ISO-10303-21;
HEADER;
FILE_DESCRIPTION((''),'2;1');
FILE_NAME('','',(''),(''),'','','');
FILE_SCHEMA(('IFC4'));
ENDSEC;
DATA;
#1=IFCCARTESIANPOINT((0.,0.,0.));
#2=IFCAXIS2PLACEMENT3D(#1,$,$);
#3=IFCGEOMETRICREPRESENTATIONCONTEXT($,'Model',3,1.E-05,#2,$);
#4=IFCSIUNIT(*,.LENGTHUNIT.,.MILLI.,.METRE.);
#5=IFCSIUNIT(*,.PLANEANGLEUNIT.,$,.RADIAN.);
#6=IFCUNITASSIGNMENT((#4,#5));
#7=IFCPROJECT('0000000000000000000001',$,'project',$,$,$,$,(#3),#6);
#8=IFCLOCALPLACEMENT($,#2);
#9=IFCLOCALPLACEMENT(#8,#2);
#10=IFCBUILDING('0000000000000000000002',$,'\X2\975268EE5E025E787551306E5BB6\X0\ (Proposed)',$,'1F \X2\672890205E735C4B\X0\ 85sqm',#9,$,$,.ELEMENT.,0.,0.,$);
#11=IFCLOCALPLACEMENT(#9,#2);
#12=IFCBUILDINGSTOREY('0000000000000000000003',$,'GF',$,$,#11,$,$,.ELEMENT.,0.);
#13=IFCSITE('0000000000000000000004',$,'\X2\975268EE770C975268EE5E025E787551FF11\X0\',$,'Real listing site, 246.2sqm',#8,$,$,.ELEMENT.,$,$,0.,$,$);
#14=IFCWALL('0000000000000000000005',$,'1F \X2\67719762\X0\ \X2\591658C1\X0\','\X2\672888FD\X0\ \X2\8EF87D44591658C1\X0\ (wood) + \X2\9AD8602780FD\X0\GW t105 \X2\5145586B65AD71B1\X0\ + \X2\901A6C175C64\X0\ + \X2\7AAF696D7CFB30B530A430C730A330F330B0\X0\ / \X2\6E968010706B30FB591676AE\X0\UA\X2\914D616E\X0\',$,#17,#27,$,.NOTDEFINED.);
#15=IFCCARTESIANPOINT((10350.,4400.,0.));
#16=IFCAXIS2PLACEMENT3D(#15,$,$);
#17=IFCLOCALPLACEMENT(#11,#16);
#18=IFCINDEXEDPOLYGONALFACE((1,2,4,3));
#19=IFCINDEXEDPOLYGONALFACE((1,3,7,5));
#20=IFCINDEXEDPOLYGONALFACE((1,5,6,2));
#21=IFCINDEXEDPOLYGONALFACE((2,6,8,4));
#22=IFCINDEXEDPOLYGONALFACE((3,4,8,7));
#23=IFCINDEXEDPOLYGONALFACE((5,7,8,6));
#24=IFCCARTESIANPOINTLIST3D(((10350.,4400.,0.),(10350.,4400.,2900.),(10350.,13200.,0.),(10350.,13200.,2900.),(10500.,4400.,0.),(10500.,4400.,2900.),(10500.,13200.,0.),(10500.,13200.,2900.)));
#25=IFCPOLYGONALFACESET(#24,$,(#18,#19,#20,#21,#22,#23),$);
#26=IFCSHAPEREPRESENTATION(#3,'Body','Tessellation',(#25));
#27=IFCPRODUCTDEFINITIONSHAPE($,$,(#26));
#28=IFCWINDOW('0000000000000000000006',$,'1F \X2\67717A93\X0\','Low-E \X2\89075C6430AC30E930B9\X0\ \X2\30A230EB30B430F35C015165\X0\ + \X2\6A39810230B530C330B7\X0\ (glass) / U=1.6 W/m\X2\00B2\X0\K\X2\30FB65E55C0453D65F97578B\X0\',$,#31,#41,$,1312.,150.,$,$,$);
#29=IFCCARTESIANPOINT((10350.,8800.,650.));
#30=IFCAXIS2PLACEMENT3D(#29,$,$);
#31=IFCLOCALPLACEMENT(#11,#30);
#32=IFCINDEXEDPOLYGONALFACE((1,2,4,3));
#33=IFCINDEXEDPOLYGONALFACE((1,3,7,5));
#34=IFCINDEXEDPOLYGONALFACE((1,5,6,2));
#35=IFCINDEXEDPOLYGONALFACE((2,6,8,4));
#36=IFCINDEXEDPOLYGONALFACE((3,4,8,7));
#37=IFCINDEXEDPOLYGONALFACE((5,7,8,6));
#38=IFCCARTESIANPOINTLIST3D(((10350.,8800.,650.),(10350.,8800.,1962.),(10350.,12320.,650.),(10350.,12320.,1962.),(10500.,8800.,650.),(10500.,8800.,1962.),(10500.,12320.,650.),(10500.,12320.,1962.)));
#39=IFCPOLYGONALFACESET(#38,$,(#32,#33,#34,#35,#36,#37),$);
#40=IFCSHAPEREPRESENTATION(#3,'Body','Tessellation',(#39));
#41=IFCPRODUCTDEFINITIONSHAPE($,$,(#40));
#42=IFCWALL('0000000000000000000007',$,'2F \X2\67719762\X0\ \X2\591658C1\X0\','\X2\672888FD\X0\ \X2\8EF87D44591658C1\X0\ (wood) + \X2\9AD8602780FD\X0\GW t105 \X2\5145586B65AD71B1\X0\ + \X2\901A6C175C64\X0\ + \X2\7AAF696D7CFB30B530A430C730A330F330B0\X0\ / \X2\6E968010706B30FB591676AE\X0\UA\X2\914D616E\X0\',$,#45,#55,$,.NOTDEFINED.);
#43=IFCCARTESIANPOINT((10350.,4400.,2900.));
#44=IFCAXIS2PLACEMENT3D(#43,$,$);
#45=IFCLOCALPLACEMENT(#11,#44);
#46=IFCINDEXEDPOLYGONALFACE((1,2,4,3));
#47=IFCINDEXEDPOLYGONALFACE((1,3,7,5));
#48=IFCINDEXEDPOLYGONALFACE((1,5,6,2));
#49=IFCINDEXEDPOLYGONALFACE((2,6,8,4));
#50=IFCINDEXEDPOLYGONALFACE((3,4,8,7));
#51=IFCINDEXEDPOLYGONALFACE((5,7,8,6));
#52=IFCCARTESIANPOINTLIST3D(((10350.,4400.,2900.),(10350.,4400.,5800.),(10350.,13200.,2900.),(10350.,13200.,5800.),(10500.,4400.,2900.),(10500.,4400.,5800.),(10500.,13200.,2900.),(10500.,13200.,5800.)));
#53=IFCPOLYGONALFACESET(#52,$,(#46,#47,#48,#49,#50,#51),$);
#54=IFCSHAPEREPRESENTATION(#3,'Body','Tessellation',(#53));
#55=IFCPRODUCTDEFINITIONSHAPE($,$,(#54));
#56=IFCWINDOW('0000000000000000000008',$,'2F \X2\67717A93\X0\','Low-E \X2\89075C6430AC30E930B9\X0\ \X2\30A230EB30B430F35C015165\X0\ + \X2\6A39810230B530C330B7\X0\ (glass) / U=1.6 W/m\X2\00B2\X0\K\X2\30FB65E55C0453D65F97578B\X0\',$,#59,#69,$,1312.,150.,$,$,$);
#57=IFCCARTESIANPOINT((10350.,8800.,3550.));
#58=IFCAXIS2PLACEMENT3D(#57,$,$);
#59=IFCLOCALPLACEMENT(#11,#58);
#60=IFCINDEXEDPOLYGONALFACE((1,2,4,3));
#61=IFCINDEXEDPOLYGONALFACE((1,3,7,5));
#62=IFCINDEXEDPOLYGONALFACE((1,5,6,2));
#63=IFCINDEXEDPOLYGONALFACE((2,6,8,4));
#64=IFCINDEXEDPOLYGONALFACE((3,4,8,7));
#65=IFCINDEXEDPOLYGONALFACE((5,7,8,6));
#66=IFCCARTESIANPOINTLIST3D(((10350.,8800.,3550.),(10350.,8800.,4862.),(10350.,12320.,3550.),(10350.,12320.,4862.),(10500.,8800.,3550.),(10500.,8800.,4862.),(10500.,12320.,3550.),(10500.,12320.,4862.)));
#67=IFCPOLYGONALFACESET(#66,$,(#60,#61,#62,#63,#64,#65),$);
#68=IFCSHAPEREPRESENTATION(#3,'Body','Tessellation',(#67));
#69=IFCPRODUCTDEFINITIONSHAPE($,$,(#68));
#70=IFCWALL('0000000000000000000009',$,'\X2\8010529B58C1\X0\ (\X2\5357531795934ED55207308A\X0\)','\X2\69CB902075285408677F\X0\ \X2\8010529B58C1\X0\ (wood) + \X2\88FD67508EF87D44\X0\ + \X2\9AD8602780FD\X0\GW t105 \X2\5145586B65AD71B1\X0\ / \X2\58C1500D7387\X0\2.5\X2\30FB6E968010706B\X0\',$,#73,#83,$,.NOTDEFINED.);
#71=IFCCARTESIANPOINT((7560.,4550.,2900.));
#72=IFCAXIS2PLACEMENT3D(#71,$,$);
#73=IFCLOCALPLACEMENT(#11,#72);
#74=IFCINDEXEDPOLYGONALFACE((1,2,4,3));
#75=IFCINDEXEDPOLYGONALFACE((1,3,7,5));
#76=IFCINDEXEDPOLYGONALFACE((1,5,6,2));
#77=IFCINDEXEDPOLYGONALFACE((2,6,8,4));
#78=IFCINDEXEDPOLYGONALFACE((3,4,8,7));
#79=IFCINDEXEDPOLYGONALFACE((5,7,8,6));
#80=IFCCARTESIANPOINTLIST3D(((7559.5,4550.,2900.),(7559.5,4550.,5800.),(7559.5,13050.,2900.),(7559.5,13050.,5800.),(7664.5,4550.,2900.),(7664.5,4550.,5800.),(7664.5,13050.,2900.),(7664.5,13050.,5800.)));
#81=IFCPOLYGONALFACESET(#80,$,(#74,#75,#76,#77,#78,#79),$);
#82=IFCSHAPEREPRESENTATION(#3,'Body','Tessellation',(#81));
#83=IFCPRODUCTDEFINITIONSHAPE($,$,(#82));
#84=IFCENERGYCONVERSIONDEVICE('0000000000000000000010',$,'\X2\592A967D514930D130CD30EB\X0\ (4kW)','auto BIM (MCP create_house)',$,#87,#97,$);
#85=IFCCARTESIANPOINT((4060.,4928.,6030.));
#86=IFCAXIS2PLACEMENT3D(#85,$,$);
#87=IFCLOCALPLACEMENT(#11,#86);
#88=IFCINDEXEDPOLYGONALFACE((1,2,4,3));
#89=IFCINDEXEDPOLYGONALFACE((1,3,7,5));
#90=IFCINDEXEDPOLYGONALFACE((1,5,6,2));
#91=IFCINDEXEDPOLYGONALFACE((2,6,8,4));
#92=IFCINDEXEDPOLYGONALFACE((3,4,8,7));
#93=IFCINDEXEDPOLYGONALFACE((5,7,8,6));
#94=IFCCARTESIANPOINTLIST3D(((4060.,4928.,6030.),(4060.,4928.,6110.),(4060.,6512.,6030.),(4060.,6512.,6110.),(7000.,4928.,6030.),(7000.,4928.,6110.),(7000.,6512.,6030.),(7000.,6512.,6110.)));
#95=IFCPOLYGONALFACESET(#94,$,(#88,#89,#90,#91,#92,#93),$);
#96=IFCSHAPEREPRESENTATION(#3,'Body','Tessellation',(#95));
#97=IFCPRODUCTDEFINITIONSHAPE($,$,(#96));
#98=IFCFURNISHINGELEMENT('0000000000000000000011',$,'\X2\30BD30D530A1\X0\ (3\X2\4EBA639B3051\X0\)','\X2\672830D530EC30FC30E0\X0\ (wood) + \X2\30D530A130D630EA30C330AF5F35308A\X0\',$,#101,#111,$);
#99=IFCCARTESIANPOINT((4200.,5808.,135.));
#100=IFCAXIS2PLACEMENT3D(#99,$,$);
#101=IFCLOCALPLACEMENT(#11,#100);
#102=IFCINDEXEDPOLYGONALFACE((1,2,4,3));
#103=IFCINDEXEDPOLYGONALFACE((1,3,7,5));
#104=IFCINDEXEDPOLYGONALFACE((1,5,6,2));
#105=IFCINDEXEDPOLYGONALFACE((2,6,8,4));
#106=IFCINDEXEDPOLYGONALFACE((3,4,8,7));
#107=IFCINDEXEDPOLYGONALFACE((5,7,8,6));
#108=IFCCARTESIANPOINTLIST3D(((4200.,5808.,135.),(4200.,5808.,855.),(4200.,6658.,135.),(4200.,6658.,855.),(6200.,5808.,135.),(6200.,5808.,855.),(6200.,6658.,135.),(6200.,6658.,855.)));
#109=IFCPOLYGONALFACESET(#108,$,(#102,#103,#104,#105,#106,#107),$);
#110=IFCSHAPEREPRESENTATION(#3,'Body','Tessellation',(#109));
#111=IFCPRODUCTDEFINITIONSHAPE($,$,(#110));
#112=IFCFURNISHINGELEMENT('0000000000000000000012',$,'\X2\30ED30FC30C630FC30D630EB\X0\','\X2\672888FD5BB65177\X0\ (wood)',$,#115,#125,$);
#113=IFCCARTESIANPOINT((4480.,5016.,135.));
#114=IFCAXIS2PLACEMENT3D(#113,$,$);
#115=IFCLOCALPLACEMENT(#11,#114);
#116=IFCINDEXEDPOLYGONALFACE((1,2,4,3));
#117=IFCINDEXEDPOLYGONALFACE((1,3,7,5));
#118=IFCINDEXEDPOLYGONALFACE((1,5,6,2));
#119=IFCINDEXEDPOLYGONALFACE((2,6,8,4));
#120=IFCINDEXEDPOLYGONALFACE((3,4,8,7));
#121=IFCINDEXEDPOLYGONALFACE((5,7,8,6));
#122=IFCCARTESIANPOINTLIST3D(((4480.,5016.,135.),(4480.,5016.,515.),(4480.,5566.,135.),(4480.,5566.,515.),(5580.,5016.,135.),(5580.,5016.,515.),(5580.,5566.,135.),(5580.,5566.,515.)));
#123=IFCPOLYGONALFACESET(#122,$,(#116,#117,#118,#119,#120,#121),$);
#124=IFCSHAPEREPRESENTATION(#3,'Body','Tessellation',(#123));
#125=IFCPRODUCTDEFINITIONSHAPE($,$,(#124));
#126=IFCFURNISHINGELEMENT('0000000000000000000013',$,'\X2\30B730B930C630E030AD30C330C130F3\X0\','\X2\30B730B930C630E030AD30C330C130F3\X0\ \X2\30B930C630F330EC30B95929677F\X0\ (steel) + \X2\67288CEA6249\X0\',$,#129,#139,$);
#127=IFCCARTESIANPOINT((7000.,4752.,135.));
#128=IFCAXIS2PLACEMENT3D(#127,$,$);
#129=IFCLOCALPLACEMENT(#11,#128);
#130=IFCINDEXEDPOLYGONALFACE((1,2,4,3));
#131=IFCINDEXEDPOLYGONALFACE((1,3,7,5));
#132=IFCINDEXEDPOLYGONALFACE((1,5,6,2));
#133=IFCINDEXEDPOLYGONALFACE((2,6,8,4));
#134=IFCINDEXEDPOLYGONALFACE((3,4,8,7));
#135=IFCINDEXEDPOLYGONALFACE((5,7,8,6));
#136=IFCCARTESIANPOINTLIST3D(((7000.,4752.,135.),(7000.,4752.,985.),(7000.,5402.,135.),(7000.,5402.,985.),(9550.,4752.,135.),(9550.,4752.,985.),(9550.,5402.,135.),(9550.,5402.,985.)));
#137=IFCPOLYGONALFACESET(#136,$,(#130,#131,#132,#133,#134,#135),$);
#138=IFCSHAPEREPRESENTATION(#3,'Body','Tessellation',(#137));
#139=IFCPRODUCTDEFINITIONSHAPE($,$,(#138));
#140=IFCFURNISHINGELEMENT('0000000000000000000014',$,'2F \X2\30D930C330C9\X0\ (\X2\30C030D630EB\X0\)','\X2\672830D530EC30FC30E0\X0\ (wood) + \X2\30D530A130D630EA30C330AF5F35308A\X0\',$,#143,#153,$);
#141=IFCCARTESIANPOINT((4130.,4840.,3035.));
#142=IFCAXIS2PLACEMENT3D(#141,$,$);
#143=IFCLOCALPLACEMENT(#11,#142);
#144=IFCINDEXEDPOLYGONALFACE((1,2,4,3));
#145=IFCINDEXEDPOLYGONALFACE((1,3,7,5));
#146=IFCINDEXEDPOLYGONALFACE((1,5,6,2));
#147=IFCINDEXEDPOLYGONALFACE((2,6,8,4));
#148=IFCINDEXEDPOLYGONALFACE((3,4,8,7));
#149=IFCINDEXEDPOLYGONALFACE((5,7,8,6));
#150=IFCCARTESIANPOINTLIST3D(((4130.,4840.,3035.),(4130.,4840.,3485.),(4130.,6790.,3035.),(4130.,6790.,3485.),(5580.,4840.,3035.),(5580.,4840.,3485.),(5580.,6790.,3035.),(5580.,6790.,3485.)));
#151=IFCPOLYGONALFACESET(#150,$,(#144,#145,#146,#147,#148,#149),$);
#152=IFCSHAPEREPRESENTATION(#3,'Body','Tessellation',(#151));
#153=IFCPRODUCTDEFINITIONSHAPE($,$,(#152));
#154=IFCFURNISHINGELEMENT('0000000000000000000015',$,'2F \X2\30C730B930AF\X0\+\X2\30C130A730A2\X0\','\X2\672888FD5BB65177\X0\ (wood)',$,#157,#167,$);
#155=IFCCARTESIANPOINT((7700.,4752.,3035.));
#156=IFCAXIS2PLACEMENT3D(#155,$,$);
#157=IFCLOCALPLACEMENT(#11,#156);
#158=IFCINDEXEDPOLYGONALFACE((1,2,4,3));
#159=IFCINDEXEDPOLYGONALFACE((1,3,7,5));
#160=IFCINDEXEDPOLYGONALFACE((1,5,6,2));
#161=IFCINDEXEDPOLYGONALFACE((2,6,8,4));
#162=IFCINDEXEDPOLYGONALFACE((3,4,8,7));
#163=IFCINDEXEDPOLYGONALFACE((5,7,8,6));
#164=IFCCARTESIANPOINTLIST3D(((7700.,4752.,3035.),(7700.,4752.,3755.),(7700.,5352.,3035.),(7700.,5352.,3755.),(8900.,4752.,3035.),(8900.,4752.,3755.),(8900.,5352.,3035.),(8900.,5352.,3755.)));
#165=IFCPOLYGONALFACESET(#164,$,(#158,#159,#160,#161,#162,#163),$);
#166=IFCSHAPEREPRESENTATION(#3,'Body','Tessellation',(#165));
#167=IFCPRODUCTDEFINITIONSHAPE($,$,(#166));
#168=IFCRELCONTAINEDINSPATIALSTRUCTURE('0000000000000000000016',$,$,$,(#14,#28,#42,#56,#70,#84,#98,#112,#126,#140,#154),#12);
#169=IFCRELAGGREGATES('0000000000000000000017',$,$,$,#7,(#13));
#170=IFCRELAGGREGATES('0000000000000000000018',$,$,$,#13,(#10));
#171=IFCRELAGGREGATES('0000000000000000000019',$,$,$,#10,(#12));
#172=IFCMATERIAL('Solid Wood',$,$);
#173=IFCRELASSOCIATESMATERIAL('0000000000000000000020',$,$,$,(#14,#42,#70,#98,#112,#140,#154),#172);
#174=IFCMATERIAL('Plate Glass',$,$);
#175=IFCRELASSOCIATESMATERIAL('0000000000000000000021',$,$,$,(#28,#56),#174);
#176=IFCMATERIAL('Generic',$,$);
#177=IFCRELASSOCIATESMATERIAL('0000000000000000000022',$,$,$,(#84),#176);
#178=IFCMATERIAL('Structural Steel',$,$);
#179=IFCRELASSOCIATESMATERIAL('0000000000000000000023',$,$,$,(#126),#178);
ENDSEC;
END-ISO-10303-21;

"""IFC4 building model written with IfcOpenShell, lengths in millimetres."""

from ifc_helpers import new_model, si_unit, frame, frame_2d, origin, place, context, project, spatial, rectangle, extrude, material, element, fill, save


model = new_model("IFC4")

# Units and contexts
model_context = context("Model", 3, precision=1e-05, world=origin())
ifc_project = project(units=[si_unit("LENGTHUNIT", "METRE", prefix="MILLI"), si_unit("PLANEANGLEUNIT", "RADIAN")], contexts=[model_context])

# Site, building, storey
site_placement = place(None, origin())
site = spatial("IfcSite", under=ifc_project, at=site_placement, Name="青森県青森市幸畑１", ObjectType="Real listing site, 246.2sqm", CompositionType="ELEMENT", RefElevation=0.0)
building_placement = place(site_placement, origin())
building = spatial("IfcBuilding", under=site, at=building_placement, Name="青森市幸畑の家 (Proposed)", ObjectType="1F 木造平屋 85sqm", CompositionType="ELEMENT", ElevationOfRefHeight=0.0, ElevationOfTerrain=0.0)
storey_placement = place(building_placement, origin())
storey = spatial("IfcBuildingStorey", under=building, at=storey_placement, Name="GF", CompositionType="ELEMENT", Elevation=0.0)

# Wall, opening, window
ifc_material_1 = material(Name="Solid Wood")
wall_1_placement = place(storey_placement, frame((10350.0, 4400.0, 0.0)))
wall_1 = element("IfcWall", 1, at=wall_1_placement, inside=storey, material=ifc_material_1, Name="1F 東面 外壁", Description="木製 軸組外壁 (wood) + 高性能GW t105 充填断熱 + 通気層 + 窯業系サイディング / 準耐火・外皮UA配慮", PredefinedType="NOTDEFINED", context=model_context, shape_type="SweptSolid", body=[
    extrude(rectangle(XDim=150.0, YDim=8800.0, at=frame_2d((75.0, 4400.0))), frame((10350.0, 4400.0, 0.0)), (0.0, 0.0, 1.0), 2900.0),
])
opening_1_placement = place(storey_placement, frame((10350.0, 8800.0, 650.0)))
opening_1 = element("IfcOpeningElement", 2, at=opening_1_placement, cuts=wall_1, PredefinedType="NOTDEFINED", context=model_context, shape_type="SweptSolid", body=[
    extrude(rectangle(XDim=150.0, YDim=3520.0, at=frame_2d((75.0, 1760.0))), frame((10350.0, 8800.0, 650.0)), (0.0, 0.0, 1.0), 1312.0),
])
ifc_material_2 = material(Name="Plate Glass")
window_1_placement = place(storey_placement, frame((10350.0, 8800.0, 650.0)))
window_1 = element("IfcWindow", 3, at=window_1_placement, inside=storey, material=ifc_material_2, Name="1F 東窓", Description="Low-E 複層ガラス アルゴン封入 + 樹脂サッシ (glass) / U=1.6 W/m²K・日射取得型", OverallHeight=1312.0, OverallWidth=150.0, context=model_context, shape_type="SweptSolid", body=[
    extrude(rectangle(XDim=150.0, YDim=3520.0, at=frame_2d((75.0, 1760.0))), frame((10350.0, 8800.0, 650.0)), (0.0, 0.0, 1.0), 1312.0),
])
fill(opening_1, window_1)

# Wall, opening, window
wall_2_placement = place(storey_placement, frame((10350.0, 4400.0, 2900.0)))
wall_2 = element("IfcWall", 4, at=wall_2_placement, inside=storey, material=ifc_material_1, Name="2F 東面 外壁", Description="木製 軸組外壁 (wood) + 高性能GW t105 充填断熱 + 通気層 + 窯業系サイディング / 準耐火・外皮UA配慮", PredefinedType="NOTDEFINED", context=model_context, shape_type="SweptSolid", body=[
    extrude(rectangle(XDim=150.0, YDim=8800.0, at=frame_2d((75.0, 4400.0))), frame((10350.0, 4400.0, 2900.0)), (0.0, 0.0, 1.0), 2900.0),
])
opening_2_placement = place(storey_placement, frame((10350.0, 8800.0, 3550.0)))
opening_2 = element("IfcOpeningElement", 5, at=opening_2_placement, cuts=wall_2, PredefinedType="NOTDEFINED", context=model_context, shape_type="SweptSolid", body=[
    extrude(rectangle(XDim=150.0, YDim=3520.0, at=frame_2d((75.0, 1760.0))), frame((10350.0, 8800.0, 3550.0)), (0.0, 0.0, 1.0), 1312.0),
])
window_2_placement = place(storey_placement, frame((10350.0, 8800.0, 3550.0)))
window_2 = element("IfcWindow", 6, at=window_2_placement, inside=storey, material=ifc_material_2, Name="2F 東窓", Description="Low-E 複層ガラス アルゴン封入 + 樹脂サッシ (glass) / U=1.6 W/m²K・日射取得型", OverallHeight=1312.0, OverallWidth=150.0, context=model_context, shape_type="SweptSolid", body=[
    extrude(rectangle(XDim=150.0, YDim=3520.0, at=frame_2d((75.0, 1760.0))), frame((10350.0, 8800.0, 3550.0)), (0.0, 0.0, 1.0), 1312.0),
])
fill(opening_2, window_2)

# Wall
wall_3_placement = place(storey_placement, frame((7560.0, 4550.0, 2900.0)))
element("IfcWall", 7, at=wall_3_placement, inside=storey, material=ifc_material_1, Name="耐力壁 (南北間仕切り)", Description="構造用合板 耐力壁 (wood) + 製材軸組 + 高性能GW t105 充填断熱 / 壁倍率2.5・準耐火", PredefinedType="NOTDEFINED", context=model_context, shape_type="SweptSolid", body=[
    extrude(rectangle(XDim=105.0, YDim=8500.0, at=frame_2d((52.0, 4250.0))), frame((7560.0, 4550.0, 2900.0)), (0.0, 0.0, 1.0), 2900.0),
])

# Energy conversion device
ifc_material_3 = material(Name="Generic")
energy_conversion_device_placement = place(storey_placement, frame((4060.0, 4928.0, 6030.0)))
element("IfcEnergyConversionDevice", 8, at=energy_conversion_device_placement, inside=storey, material=ifc_material_3, Name="太陽光パネル (4kW)", Description="auto BIM (MCP create_house)", context=model_context, shape_type="SweptSolid", body=[
    extrude(rectangle(XDim=2940.0, YDim=1584.0, at=frame_2d((1470.0, 792.0))), frame((4060.0, 4928.0, 6030.0)), (0.0, 0.0, 1.0), 80.0),
])

# Furnishing elements
furnishing_1_placement = place(storey_placement, frame((4200.0, 5808.0, 135.0)))
element("IfcFurnishingElement", 9, at=furnishing_1_placement, inside=storey, material=ifc_material_1, Name="ソファ (3人掛け)", Description="木フレーム (wood) + ファブリック張り", context=model_context, shape_type="SweptSolid", body=[
    extrude(rectangle(XDim=2000.0, YDim=850.0, at=frame_2d((1000.0, 425.0))), frame((4200.0, 5808.0, 135.0)), (0.0, 0.0, 1.0), 720.0),
])
furnishing_2_placement = place(storey_placement, frame((4480.0, 5016.0, 135.0)))
element("IfcFurnishingElement", 10, at=furnishing_2_placement, inside=storey, material=ifc_material_1, Name="ローテーブル", Description="木製家具 (wood)", context=model_context, shape_type="SweptSolid", body=[
    extrude(rectangle(XDim=1100.0, YDim=550.0, at=frame_2d((550.0, 275.0))), frame((4480.0, 5016.0, 135.0)), (0.0, 0.0, 1.0), 380.0),
])
ifc_material_4 = material(Name="Structural Steel")
furnishing_3_placement = place(storey_placement, frame((7000.0, 4752.0, 135.0)))
element("IfcFurnishingElement", 11, at=furnishing_3_placement, inside=storey, material=ifc_material_4, Name="システムキッチン", Description="システムキッチン ステンレス天板 (steel) + 木質扉", context=model_context, shape_type="SweptSolid", body=[
    extrude(rectangle(XDim=2550.0, YDim=650.0, at=frame_2d((1275.0, 325.0))), frame((7000.0, 4752.0, 135.0)), (0.0, 0.0, 1.0), 850.0),
])
furnishing_4_placement = place(storey_placement, frame((4130.0, 4840.0, 3035.0)))
element("IfcFurnishingElement", 12, at=furnishing_4_placement, inside=storey, material=ifc_material_1, Name="2F ベッド (ダブル)", Description="木フレーム (wood) + ファブリック張り", context=model_context, shape_type="SweptSolid", body=[
    extrude(rectangle(XDim=1450.0, YDim=1950.0, at=frame_2d((725.0, 975.0))), frame((4130.0, 4840.0, 3035.0)), (0.0, 0.0, 1.0), 450.0),
])
furnishing_5_placement = place(storey_placement, frame((7700.0, 4752.0, 3035.0)))
element("IfcFurnishingElement", 13, at=furnishing_5_placement, inside=storey, material=ifc_material_1, Name="2F デスク+チェア", Description="木製家具 (wood)", context=model_context, shape_type="SweptSolid", body=[
    extrude(rectangle(XDim=1200.0, YDim=600.0, at=frame_2d((600.0, 300.0))), frame((7700.0, 4752.0, 3035.0)), (0.0, 0.0, 1.0), 720.0),
])

save(model, "model.ifc")
